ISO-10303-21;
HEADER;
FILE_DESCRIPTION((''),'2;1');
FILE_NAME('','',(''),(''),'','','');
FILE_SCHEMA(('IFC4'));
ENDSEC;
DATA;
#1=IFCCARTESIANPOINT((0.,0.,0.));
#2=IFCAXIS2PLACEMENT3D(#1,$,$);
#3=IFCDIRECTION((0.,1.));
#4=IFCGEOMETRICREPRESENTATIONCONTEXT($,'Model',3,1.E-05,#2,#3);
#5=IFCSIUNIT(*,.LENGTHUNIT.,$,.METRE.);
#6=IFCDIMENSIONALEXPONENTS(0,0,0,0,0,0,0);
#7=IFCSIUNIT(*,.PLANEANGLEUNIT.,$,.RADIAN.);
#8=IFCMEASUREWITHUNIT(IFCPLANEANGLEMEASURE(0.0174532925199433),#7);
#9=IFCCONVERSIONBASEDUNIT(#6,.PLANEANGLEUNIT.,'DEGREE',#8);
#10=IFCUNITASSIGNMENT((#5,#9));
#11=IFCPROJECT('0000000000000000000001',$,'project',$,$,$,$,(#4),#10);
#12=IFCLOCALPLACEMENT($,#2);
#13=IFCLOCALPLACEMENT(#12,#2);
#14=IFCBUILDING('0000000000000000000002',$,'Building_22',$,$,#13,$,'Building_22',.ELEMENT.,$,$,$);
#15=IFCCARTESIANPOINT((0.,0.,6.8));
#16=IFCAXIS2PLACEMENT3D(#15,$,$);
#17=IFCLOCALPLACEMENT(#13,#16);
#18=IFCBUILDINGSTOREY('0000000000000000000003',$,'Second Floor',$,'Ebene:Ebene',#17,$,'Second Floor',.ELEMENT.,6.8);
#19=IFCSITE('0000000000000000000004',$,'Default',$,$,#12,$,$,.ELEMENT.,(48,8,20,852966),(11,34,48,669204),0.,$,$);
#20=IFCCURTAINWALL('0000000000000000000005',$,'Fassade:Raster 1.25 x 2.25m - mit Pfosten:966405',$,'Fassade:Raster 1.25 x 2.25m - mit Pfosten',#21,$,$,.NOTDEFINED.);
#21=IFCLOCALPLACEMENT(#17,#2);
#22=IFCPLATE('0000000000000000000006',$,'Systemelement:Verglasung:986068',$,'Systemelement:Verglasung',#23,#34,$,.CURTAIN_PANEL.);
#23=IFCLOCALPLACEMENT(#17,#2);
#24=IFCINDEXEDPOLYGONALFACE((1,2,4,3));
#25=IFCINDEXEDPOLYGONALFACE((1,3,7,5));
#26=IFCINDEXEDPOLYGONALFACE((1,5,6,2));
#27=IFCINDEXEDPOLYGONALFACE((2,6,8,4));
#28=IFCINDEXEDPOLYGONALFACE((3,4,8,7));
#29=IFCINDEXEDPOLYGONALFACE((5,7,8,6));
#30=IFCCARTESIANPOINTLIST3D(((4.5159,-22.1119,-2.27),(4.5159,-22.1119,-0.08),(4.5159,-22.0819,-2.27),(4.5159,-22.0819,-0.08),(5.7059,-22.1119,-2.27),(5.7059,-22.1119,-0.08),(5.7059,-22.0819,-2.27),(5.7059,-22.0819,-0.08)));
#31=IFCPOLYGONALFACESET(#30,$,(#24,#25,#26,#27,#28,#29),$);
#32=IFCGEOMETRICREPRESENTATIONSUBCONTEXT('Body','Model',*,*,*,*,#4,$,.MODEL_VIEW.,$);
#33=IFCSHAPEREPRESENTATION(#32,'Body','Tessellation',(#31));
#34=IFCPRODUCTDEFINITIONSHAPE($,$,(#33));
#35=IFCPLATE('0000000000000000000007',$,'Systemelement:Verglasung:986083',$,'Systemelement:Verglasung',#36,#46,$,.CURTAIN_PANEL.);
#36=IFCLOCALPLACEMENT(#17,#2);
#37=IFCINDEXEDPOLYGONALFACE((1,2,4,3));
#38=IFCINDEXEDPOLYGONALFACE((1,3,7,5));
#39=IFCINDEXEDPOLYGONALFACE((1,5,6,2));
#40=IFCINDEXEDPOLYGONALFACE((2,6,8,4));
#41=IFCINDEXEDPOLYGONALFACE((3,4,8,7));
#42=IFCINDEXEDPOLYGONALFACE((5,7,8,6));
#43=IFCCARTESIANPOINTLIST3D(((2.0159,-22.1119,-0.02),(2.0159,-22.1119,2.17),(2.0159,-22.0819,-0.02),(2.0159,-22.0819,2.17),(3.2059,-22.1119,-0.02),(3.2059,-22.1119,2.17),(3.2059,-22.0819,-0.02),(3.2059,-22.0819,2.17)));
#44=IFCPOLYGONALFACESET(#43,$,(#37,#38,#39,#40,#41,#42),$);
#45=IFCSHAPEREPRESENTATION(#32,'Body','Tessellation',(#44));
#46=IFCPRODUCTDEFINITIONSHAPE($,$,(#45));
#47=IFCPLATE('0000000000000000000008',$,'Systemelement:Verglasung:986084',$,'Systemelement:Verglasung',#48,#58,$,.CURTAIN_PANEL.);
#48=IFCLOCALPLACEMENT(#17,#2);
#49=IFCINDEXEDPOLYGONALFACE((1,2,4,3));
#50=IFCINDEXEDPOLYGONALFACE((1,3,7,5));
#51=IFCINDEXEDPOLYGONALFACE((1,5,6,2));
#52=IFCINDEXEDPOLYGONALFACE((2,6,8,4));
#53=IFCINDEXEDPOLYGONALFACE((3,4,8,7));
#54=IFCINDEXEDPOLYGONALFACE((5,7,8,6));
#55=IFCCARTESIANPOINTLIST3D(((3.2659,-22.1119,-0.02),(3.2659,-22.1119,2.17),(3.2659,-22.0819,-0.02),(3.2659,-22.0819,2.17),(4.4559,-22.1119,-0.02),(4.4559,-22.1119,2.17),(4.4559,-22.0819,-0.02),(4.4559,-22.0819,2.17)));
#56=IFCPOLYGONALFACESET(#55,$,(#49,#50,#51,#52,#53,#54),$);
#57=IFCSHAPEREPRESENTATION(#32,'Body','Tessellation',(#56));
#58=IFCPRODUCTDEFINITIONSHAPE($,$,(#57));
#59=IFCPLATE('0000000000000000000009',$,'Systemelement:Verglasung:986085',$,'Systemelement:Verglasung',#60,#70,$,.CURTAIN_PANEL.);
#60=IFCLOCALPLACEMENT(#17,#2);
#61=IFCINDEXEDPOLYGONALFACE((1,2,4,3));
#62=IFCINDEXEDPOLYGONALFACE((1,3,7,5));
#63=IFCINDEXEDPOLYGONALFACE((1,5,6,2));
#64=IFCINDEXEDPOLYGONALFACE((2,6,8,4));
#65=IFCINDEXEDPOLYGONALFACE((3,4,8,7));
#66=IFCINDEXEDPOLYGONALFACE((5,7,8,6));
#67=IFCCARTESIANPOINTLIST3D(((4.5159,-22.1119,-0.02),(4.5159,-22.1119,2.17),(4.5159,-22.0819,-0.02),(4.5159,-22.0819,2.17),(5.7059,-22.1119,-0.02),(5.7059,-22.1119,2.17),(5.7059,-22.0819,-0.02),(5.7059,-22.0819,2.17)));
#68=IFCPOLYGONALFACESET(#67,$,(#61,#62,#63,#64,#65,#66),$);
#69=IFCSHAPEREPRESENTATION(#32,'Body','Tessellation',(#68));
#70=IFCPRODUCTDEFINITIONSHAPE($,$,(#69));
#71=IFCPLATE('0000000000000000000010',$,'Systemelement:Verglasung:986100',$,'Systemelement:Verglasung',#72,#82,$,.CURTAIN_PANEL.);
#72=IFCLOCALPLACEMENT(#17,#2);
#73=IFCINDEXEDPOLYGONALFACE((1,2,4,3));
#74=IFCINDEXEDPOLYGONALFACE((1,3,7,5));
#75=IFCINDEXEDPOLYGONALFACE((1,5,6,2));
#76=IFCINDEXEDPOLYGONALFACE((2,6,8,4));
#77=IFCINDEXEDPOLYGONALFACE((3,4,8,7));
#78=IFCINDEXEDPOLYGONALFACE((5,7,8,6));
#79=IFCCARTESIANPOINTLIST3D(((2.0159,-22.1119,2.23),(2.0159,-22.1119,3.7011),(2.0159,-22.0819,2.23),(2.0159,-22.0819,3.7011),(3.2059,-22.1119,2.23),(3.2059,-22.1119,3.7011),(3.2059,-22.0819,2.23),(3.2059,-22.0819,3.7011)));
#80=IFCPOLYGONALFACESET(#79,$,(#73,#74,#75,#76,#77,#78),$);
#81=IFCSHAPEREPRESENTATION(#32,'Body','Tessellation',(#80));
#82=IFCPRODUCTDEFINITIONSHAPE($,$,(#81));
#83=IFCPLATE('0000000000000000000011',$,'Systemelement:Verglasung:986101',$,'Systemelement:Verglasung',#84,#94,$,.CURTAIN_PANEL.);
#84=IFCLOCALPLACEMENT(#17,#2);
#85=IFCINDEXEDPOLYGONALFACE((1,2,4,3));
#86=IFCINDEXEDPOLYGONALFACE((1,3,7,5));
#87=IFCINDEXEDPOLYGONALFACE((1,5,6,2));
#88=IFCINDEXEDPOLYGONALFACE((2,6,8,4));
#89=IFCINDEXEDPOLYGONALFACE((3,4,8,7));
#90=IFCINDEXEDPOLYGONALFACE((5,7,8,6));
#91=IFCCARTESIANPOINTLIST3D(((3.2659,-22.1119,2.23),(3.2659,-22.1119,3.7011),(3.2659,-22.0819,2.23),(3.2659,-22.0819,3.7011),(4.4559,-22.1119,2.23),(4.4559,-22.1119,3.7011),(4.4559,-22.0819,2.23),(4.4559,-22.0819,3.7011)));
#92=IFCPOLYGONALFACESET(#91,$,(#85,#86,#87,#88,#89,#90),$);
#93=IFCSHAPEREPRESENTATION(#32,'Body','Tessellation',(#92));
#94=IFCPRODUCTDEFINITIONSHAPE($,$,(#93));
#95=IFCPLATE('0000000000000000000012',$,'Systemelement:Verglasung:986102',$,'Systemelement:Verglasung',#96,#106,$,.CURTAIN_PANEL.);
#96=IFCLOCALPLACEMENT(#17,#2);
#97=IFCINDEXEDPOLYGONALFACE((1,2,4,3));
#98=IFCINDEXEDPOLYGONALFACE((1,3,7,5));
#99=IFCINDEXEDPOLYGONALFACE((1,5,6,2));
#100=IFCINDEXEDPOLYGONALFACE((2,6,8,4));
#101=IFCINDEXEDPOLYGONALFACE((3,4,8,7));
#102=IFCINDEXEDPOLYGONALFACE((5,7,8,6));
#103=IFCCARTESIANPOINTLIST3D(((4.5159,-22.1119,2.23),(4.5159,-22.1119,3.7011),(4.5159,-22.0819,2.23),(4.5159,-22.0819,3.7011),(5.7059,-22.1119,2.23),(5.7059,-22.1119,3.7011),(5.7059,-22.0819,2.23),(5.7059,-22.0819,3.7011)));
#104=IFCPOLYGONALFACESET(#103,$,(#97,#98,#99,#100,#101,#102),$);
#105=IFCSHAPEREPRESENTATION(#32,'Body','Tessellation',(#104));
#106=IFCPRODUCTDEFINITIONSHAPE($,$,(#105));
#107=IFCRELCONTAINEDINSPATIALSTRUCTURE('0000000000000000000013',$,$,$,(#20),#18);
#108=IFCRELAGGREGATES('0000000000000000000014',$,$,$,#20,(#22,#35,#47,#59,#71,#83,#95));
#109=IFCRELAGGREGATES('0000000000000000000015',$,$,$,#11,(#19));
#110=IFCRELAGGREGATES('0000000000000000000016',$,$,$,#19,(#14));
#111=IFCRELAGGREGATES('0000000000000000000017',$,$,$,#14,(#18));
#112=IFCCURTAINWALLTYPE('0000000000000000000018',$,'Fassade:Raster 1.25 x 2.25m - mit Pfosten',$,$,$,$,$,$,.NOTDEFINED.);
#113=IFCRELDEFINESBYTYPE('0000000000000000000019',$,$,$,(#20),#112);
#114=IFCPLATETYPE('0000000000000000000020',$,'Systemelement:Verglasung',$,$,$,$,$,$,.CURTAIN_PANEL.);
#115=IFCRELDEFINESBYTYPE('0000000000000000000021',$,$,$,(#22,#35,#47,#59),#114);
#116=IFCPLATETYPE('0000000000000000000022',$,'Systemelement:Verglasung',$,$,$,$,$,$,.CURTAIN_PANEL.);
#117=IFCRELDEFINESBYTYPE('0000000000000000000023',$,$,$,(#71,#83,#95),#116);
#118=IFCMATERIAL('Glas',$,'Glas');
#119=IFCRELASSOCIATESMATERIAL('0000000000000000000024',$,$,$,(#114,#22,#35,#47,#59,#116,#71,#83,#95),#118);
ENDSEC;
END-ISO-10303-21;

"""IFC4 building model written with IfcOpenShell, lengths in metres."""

from ifc_helpers import new_model, entity, si_unit, converted_unit, direction, frame, origin, place, context, subcontext, project, spatial, indexed_curve, outline, extrude, source, transform, mapped, material, type_object, type_shapes, element, aggregate, save


model = new_model("IFC4")

# Units and contexts
model_context = context("Model", 3, precision=1e-05, world=origin(), true_north=direction((0.0, 1.0)))
body_context = subcontext(model_context, "Body", "Model", "MODEL_VIEW")
ifc_project = project(units=[si_unit("LENGTHUNIT", "METRE"), converted_unit("PLANEANGLEUNIT", "DEGREE", entity("IfcPlaneAngleMeasure", 0.0174532925199433), si_unit("PLANEANGLEUNIT", "RADIAN"), dimensions=[0, 0, 0, 0, 0, 0, 0])], contexts=[model_context])

# Site, building, storey
site_placement = place(None, origin())
site = spatial("IfcSite", under=ifc_project, at=site_placement, Name="Default", CompositionType="ELEMENT", RefLatitude=(48, 8, 20, 852966), RefLongitude=(11, 34, 48, 669204), RefElevation=0.0)
building_placement = place(site_placement, origin())
building = spatial("IfcBuilding", under=site, at=building_placement, Name="Building_22", LongName="Building_22", CompositionType="ELEMENT")
storey_placement = place(building_placement, frame((0.0, 0.0, 6.8)))
storey = spatial("IfcBuildingStorey", under=building, at=storey_placement, Name="Second Floor", ObjectType="Ebene:Ebene", LongName="Second Floor", CompositionType="ELEMENT", Elevation=6.8)

# Curtain wall, plates
curtain_wall_type = type_object("IfcCurtainWallType", Name="Fassade:Raster 1.25 x 2.25m - mit Pfosten", PredefinedType="NOTDEFINED")
curtain_wall_placement = place(storey_placement, frame((0.0, 0.0, -6.8)))
curtain_wall = element("IfcCurtainWall", 1, at=curtain_wall_placement, inside=storey, type_object=curtain_wall_type, Name="Fassade:Raster 1.25 x 2.25m - mit Pfosten:966405", ObjectType="Fassade:Raster 1.25 x 2.25m - mit Pfosten", PredefinedType="NOTDEFINED")
ifc_material_1 = material(Name="Glas", Category="Glas")
plate_type_1 = type_object("IfcPlateType", Name="Systemelement:Verglasung", PredefinedType="CURTAIN_PANEL", material=ifc_material_1)
shared_shape_1 = source(origin(), body_context, "Body", "SweptSolid", [
    extrude(outline(indexed_curve([(-0.015, -0.595), (0.015, -0.595), (0.015, 0.595), (-0.015, 0.595), (-0.015, -0.595)], self_intersect=False)), frame((0.0, 0.0, 0.0), z_axis=(0.0, 0.0, 1.0), x_axis=(0.0, 1.0, 0.0)), (0.0, 0.0, 1.0), 2.19),
])
type_shapes(plate_type_1, [shared_shape_1])
plate_1_placement = place(curtain_wall_placement, frame((5.1109, -22.0969, 4.53)))
plate_1 = element("IfcPlate", 2, at=plate_1_placement, type_object=plate_type_1, material=ifc_material_1, Name="Systemelement:Verglasung:986068", ObjectType="Systemelement:Verglasung", PredefinedType="CURTAIN_PANEL", context=body_context, shape_type="MappedRepresentation", body=[
    mapped(shared_shape_1, transform((0.0, 0.0, 0.0), scale=1.0)),
])
plate_2_placement = place(curtain_wall_placement, frame((2.6109, -22.0969, 6.78)))
plate_2 = element("IfcPlate", 3, at=plate_2_placement, type_object=plate_type_1, material=ifc_material_1, Name="Systemelement:Verglasung:986083", ObjectType="Systemelement:Verglasung", PredefinedType="CURTAIN_PANEL", context=body_context, shape_type="MappedRepresentation", body=[
    mapped(shared_shape_1, transform((0.0, 0.0, 0.0), scale=1.0)),
])
plate_3_placement = place(curtain_wall_placement, frame((3.8609, -22.0969, 6.78)))
plate_3 = element("IfcPlate", 4, at=plate_3_placement, type_object=plate_type_1, material=ifc_material_1, Name="Systemelement:Verglasung:986084", ObjectType="Systemelement:Verglasung", PredefinedType="CURTAIN_PANEL", context=body_context, shape_type="MappedRepresentation", body=[
    mapped(shared_shape_1, transform((0.0, 0.0, 0.0), scale=1.0)),
])
plate_4_placement = place(curtain_wall_placement, frame((5.1109, -22.0969, 6.78)))
plate_4 = element("IfcPlate", 5, at=plate_4_placement, type_object=plate_type_1, material=ifc_material_1, Name="Systemelement:Verglasung:986085", ObjectType="Systemelement:Verglasung", PredefinedType="CURTAIN_PANEL", context=body_context, shape_type="MappedRepresentation", body=[
    mapped(shared_shape_1, transform((0.0, 0.0, 0.0), scale=1.0)),
])
plate_type_2 = type_object("IfcPlateType", Name="Systemelement:Verglasung", PredefinedType="CURTAIN_PANEL", material=ifc_material_1)
shared_shape_2 = source(origin(), body_context, "Body", "SweptSolid", [
    extrude(outline(indexed_curve([(-0.015, -0.595), (0.015, -0.595), (0.015, 0.595), (-0.015, 0.595), (-0.015, -0.595)], self_intersect=False)), frame((0.0, 0.0, 0.0), z_axis=(0.0, 0.0, 1.0), x_axis=(0.0, 1.0, 0.0)), (0.0, 0.0, 1.0), 1.4711),
])
type_shapes(plate_type_2, [shared_shape_2])
plate_5_placement = place(curtain_wall_placement, frame((2.6109, -22.0969, 9.03)))
plate_5 = element("IfcPlate", 6, at=plate_5_placement, type_object=plate_type_2, material=ifc_material_1, Name="Systemelement:Verglasung:986100", ObjectType="Systemelement:Verglasung", PredefinedType="CURTAIN_PANEL", context=body_context, shape_type="MappedRepresentation", body=[
    mapped(shared_shape_2, transform((0.0, 0.0, 0.0), scale=1.0)),
])
plate_6_placement = place(curtain_wall_placement, frame((3.8609, -22.0969, 9.03)))
plate_6 = element("IfcPlate", 7, at=plate_6_placement, type_object=plate_type_2, material=ifc_material_1, Name="Systemelement:Verglasung:986101", ObjectType="Systemelement:Verglasung", PredefinedType="CURTAIN_PANEL", context=body_context, shape_type="MappedRepresentation", body=[
    mapped(shared_shape_2, transform((0.0, 0.0, 0.0), scale=1.0)),
])
plate_7_placement = place(curtain_wall_placement, frame((5.1109, -22.0969, 9.03)))
plate_7 = element("IfcPlate", 8, at=plate_7_placement, type_object=plate_type_2, material=ifc_material_1, Name="Systemelement:Verglasung:986102", ObjectType="Systemelement:Verglasung", PredefinedType="CURTAIN_PANEL", context=body_context, shape_type="MappedRepresentation", body=[
    mapped(shared_shape_2, transform((0.0, 0.0, 0.0), scale=1.0)),
])
aggregate(curtain_wall, [plate_1, plate_2, plate_3, plate_4, plate_5, plate_6, plate_7])

save(model, "model.ifc")
